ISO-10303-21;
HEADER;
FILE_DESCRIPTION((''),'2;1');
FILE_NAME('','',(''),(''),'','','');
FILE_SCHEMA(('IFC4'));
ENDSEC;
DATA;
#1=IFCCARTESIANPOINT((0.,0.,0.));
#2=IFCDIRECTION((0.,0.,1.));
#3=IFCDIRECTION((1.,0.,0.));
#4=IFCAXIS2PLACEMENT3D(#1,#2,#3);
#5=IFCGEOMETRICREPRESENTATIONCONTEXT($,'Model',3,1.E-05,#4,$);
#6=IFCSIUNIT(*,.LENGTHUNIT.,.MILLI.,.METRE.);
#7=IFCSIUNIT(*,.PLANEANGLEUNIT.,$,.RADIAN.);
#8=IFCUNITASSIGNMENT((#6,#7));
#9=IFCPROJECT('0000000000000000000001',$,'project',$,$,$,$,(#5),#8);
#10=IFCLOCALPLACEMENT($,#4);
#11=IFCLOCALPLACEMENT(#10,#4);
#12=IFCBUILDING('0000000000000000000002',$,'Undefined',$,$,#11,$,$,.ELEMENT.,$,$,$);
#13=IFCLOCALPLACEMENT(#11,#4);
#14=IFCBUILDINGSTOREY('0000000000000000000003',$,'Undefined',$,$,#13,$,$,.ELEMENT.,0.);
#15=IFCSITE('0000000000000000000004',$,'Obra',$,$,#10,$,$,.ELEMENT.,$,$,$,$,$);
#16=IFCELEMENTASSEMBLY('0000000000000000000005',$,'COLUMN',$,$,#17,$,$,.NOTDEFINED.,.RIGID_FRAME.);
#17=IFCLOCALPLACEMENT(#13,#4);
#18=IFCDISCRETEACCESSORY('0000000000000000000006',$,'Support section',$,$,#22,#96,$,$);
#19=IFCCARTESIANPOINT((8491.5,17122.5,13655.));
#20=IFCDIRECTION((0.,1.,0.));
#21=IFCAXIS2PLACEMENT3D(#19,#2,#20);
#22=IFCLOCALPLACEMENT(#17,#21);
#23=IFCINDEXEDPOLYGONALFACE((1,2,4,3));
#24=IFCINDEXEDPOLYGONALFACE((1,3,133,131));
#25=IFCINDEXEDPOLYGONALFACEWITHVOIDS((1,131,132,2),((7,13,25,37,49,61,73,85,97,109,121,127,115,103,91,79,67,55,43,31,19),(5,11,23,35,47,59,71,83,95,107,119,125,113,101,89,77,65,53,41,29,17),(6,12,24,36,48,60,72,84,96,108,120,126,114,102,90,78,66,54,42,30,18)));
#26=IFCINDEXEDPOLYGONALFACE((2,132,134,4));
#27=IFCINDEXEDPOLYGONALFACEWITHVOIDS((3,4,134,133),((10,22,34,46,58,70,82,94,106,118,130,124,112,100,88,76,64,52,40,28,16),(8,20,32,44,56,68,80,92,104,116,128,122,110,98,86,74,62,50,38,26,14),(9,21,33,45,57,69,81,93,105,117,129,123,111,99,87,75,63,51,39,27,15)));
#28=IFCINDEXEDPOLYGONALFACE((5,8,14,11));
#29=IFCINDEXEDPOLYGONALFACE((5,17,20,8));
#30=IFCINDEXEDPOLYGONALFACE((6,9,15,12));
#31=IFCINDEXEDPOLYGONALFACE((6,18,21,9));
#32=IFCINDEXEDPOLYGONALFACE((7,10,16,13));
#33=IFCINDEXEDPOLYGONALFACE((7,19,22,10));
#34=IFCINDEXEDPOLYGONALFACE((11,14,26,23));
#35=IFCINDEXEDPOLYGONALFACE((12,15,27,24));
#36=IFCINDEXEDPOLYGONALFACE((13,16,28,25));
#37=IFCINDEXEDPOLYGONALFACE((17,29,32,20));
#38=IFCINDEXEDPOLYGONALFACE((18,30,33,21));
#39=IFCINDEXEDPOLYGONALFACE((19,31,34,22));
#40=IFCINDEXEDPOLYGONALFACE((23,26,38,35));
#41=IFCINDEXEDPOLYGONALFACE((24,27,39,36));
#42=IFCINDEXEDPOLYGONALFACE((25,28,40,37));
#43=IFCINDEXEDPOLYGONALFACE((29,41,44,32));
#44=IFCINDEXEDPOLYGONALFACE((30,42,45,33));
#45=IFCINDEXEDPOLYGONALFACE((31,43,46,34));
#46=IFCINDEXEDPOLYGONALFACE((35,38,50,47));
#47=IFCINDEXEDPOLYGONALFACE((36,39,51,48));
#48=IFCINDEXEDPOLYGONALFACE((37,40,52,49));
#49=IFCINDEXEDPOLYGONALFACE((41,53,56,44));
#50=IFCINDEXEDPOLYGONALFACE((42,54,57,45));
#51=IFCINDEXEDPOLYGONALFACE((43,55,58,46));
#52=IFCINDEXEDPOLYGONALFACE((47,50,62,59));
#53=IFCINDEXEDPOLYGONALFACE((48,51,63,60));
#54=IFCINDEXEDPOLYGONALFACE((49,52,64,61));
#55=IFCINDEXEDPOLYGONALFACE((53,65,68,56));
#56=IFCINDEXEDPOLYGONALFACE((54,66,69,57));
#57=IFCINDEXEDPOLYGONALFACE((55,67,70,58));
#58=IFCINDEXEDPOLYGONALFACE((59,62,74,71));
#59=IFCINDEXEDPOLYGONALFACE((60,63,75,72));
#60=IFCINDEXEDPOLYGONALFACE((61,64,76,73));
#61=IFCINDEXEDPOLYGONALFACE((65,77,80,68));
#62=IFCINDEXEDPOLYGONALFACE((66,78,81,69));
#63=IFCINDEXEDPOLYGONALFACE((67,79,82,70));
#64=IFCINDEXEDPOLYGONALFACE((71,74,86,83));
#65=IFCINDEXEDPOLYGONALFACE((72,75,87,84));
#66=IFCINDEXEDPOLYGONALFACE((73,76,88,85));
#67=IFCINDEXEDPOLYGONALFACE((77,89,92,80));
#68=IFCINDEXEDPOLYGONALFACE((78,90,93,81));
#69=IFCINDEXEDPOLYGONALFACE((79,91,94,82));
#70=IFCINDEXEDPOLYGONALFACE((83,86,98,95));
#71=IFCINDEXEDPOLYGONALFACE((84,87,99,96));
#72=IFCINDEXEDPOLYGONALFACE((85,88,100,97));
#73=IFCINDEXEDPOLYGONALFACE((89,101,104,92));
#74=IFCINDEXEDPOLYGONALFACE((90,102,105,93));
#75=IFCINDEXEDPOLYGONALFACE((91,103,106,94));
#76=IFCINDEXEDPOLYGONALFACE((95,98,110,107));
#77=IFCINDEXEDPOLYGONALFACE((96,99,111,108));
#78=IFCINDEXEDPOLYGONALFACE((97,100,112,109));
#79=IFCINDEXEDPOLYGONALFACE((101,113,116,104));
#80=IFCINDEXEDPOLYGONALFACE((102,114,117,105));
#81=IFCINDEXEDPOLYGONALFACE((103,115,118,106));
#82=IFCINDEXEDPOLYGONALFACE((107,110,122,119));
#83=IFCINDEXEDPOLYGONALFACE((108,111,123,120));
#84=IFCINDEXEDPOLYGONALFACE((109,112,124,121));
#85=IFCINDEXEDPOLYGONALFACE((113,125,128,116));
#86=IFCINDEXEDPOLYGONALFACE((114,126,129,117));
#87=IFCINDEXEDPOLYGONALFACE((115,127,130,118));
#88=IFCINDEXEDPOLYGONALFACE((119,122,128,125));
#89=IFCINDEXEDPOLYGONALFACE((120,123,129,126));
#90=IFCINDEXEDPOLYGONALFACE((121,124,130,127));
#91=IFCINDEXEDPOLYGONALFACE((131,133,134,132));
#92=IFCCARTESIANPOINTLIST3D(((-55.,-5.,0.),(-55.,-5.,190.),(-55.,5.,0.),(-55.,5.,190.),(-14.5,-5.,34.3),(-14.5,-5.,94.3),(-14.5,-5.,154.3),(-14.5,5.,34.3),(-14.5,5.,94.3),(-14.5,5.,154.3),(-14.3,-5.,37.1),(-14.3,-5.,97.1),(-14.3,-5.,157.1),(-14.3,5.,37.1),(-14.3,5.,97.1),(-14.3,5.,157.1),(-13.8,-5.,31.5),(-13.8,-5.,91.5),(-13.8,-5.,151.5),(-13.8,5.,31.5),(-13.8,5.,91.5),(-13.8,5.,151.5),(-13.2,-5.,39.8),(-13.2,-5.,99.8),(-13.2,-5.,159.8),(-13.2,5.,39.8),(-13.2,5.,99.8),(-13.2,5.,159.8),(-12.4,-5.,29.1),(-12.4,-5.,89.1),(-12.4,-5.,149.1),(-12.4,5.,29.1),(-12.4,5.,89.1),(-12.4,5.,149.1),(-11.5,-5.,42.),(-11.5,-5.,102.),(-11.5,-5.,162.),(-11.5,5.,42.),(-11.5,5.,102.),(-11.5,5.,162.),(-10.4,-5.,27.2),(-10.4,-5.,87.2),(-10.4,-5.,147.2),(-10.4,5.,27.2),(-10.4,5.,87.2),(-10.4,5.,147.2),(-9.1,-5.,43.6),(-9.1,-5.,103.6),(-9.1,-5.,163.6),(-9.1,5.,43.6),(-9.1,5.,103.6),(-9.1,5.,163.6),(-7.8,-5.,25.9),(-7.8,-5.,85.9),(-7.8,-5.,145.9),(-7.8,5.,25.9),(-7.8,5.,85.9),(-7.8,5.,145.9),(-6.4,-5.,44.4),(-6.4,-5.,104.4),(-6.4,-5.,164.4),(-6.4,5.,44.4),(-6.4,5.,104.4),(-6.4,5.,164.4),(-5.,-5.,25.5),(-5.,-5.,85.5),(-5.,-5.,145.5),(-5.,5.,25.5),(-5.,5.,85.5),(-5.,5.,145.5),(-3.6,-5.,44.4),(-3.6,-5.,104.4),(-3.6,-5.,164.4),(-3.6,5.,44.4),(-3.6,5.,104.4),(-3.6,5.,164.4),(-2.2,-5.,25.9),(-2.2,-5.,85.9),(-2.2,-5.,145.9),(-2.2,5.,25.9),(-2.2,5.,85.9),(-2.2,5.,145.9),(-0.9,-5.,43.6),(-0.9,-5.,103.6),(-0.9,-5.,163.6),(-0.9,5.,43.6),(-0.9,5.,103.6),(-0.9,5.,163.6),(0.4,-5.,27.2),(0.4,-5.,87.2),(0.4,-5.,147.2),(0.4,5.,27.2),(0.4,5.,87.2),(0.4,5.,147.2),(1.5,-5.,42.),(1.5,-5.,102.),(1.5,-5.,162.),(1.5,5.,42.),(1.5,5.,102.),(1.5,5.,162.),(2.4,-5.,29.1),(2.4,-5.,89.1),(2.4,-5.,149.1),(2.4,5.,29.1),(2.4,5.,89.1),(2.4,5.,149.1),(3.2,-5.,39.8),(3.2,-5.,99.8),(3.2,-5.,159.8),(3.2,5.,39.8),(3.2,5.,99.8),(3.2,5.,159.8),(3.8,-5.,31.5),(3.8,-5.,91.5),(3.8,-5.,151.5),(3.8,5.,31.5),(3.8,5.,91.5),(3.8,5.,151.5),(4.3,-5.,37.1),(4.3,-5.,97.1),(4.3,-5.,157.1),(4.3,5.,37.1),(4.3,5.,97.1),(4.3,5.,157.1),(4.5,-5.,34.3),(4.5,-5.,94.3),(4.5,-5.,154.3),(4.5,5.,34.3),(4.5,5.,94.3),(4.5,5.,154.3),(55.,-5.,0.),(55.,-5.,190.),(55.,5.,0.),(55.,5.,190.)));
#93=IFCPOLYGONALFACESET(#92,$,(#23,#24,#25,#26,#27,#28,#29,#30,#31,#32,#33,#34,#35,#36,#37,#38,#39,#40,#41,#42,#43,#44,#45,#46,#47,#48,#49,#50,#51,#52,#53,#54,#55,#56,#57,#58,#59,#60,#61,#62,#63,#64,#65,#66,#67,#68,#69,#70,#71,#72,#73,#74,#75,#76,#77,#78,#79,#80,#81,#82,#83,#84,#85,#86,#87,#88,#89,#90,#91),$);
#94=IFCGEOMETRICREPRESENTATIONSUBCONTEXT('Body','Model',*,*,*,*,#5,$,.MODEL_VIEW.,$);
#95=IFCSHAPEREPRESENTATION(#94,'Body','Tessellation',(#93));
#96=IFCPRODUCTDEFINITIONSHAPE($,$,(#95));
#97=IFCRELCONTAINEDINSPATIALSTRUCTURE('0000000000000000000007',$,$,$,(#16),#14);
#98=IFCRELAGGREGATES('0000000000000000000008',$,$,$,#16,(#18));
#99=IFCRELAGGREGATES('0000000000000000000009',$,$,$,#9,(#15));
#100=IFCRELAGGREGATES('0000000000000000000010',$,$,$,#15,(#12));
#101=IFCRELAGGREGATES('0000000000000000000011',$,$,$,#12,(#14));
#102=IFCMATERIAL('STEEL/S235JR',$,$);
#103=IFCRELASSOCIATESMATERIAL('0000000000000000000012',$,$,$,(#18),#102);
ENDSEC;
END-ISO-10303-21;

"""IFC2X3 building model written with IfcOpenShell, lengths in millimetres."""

from ifc_helpers import new_model, si_unit, frame, origin_with_axes, origin_2d_with_axis, place, context, subcontext, project, spatial, rectangle, circle, extrude, source, transform, mapped, material, element, aggregate, save


model = new_model("IFC2X3")

# Units and contexts
model_context = context("Model", 3, precision=1e-05, world=origin_with_axes())
body_context = subcontext(model_context, "Body", "Model", "MODEL_VIEW")
ifc_project = project(units=[si_unit("LENGTHUNIT", "METRE", prefix="MILLI"), si_unit("PLANEANGLEUNIT", "RADIAN")], contexts=[model_context])

# Site, building, storey
site_placement = place(None, origin_with_axes())
site = spatial("IfcSite", under=ifc_project, at=site_placement, Name="Obra", CompositionType="ELEMENT")
building_placement = place(site_placement, origin_with_axes())
building = spatial("IfcBuilding", under=site, at=building_placement, Name="Undefined", CompositionType="ELEMENT")
storey_placement = place(building_placement, origin_with_axes())
storey = spatial("IfcBuildingStorey", under=building, at=storey_placement, Name="Undefined", CompositionType="ELEMENT", Elevation=0.0)

# Shared definitions
ifc_material_1 = material(Name="STEEL/S235JR")

# Element assembly, discrete accessory, opening
assembly_1_placement = place(storey_placement, origin_with_axes())
assembly_1 = element("IfcElementAssembly", 1, at=assembly_1_placement, inside=storey, Name="COLUMN", AssemblyPlace="NOTDEFINED", PredefinedType="RIGID_FRAME")
discrete_accessory_1_placement = place(assembly_1_placement, frame((8491.5, 17122.5, 13655.0), z_axis=(0.0, 0.0, 1.0), x_axis=(0.0, 1.0, 0.0)))
discrete_accessory_1 = element("IfcDiscreteAccessory", 2, at=discrete_accessory_1_placement, material=ifc_material_1, Name="Support section", context=body_context, shape_type="SweptSolid", body=[
    extrude(rectangle(XDim=10.0, YDim=110.0, at=origin_2d_with_axis()), frame((0.0, 0.0, 190.0), z_axis=(0.0, 0.0, -1.0), x_axis=(0.0, 1.0, 0.0)), (0.0, 0.0, 1.0), 190.0),
])
shared_shape_1 = source(origin_with_axes(), body_context, "Body", "SweptSolid", [
    extrude(circle(Radius=9.5, at=origin_2d_with_axis()), frame((0.0, -13.6, 0.0), z_axis=(0.0, 1.0, 0.0), x_axis=(1.0, 0.0, 0.0)), (0.0, 0.0, 1.0), 10.2),
])
opening_1_placement = place(assembly_1_placement, frame((8500.0, 17167.5, 13900.0), z_axis=(0.0, -1.0, 0.0), x_axis=(0.0, 0.0, -1.0)))
element("IfcOpeningElement", 3, at=opening_1_placement, cuts=discrete_accessory_1, ObjectType="Opening", context=body_context, shape_type="MappedRepresentation", body=[
    mapped(shared_shape_1, transform((90.0, 0.0, 50.0))),
    mapped(shared_shape_1, transform((150.0, 0.0, 50.0))),
    mapped(shared_shape_1, transform((210.0, 0.0, 50.0))),
])
aggregate(assembly_1, [discrete_accessory_1])

save(model, "model.ifc")
